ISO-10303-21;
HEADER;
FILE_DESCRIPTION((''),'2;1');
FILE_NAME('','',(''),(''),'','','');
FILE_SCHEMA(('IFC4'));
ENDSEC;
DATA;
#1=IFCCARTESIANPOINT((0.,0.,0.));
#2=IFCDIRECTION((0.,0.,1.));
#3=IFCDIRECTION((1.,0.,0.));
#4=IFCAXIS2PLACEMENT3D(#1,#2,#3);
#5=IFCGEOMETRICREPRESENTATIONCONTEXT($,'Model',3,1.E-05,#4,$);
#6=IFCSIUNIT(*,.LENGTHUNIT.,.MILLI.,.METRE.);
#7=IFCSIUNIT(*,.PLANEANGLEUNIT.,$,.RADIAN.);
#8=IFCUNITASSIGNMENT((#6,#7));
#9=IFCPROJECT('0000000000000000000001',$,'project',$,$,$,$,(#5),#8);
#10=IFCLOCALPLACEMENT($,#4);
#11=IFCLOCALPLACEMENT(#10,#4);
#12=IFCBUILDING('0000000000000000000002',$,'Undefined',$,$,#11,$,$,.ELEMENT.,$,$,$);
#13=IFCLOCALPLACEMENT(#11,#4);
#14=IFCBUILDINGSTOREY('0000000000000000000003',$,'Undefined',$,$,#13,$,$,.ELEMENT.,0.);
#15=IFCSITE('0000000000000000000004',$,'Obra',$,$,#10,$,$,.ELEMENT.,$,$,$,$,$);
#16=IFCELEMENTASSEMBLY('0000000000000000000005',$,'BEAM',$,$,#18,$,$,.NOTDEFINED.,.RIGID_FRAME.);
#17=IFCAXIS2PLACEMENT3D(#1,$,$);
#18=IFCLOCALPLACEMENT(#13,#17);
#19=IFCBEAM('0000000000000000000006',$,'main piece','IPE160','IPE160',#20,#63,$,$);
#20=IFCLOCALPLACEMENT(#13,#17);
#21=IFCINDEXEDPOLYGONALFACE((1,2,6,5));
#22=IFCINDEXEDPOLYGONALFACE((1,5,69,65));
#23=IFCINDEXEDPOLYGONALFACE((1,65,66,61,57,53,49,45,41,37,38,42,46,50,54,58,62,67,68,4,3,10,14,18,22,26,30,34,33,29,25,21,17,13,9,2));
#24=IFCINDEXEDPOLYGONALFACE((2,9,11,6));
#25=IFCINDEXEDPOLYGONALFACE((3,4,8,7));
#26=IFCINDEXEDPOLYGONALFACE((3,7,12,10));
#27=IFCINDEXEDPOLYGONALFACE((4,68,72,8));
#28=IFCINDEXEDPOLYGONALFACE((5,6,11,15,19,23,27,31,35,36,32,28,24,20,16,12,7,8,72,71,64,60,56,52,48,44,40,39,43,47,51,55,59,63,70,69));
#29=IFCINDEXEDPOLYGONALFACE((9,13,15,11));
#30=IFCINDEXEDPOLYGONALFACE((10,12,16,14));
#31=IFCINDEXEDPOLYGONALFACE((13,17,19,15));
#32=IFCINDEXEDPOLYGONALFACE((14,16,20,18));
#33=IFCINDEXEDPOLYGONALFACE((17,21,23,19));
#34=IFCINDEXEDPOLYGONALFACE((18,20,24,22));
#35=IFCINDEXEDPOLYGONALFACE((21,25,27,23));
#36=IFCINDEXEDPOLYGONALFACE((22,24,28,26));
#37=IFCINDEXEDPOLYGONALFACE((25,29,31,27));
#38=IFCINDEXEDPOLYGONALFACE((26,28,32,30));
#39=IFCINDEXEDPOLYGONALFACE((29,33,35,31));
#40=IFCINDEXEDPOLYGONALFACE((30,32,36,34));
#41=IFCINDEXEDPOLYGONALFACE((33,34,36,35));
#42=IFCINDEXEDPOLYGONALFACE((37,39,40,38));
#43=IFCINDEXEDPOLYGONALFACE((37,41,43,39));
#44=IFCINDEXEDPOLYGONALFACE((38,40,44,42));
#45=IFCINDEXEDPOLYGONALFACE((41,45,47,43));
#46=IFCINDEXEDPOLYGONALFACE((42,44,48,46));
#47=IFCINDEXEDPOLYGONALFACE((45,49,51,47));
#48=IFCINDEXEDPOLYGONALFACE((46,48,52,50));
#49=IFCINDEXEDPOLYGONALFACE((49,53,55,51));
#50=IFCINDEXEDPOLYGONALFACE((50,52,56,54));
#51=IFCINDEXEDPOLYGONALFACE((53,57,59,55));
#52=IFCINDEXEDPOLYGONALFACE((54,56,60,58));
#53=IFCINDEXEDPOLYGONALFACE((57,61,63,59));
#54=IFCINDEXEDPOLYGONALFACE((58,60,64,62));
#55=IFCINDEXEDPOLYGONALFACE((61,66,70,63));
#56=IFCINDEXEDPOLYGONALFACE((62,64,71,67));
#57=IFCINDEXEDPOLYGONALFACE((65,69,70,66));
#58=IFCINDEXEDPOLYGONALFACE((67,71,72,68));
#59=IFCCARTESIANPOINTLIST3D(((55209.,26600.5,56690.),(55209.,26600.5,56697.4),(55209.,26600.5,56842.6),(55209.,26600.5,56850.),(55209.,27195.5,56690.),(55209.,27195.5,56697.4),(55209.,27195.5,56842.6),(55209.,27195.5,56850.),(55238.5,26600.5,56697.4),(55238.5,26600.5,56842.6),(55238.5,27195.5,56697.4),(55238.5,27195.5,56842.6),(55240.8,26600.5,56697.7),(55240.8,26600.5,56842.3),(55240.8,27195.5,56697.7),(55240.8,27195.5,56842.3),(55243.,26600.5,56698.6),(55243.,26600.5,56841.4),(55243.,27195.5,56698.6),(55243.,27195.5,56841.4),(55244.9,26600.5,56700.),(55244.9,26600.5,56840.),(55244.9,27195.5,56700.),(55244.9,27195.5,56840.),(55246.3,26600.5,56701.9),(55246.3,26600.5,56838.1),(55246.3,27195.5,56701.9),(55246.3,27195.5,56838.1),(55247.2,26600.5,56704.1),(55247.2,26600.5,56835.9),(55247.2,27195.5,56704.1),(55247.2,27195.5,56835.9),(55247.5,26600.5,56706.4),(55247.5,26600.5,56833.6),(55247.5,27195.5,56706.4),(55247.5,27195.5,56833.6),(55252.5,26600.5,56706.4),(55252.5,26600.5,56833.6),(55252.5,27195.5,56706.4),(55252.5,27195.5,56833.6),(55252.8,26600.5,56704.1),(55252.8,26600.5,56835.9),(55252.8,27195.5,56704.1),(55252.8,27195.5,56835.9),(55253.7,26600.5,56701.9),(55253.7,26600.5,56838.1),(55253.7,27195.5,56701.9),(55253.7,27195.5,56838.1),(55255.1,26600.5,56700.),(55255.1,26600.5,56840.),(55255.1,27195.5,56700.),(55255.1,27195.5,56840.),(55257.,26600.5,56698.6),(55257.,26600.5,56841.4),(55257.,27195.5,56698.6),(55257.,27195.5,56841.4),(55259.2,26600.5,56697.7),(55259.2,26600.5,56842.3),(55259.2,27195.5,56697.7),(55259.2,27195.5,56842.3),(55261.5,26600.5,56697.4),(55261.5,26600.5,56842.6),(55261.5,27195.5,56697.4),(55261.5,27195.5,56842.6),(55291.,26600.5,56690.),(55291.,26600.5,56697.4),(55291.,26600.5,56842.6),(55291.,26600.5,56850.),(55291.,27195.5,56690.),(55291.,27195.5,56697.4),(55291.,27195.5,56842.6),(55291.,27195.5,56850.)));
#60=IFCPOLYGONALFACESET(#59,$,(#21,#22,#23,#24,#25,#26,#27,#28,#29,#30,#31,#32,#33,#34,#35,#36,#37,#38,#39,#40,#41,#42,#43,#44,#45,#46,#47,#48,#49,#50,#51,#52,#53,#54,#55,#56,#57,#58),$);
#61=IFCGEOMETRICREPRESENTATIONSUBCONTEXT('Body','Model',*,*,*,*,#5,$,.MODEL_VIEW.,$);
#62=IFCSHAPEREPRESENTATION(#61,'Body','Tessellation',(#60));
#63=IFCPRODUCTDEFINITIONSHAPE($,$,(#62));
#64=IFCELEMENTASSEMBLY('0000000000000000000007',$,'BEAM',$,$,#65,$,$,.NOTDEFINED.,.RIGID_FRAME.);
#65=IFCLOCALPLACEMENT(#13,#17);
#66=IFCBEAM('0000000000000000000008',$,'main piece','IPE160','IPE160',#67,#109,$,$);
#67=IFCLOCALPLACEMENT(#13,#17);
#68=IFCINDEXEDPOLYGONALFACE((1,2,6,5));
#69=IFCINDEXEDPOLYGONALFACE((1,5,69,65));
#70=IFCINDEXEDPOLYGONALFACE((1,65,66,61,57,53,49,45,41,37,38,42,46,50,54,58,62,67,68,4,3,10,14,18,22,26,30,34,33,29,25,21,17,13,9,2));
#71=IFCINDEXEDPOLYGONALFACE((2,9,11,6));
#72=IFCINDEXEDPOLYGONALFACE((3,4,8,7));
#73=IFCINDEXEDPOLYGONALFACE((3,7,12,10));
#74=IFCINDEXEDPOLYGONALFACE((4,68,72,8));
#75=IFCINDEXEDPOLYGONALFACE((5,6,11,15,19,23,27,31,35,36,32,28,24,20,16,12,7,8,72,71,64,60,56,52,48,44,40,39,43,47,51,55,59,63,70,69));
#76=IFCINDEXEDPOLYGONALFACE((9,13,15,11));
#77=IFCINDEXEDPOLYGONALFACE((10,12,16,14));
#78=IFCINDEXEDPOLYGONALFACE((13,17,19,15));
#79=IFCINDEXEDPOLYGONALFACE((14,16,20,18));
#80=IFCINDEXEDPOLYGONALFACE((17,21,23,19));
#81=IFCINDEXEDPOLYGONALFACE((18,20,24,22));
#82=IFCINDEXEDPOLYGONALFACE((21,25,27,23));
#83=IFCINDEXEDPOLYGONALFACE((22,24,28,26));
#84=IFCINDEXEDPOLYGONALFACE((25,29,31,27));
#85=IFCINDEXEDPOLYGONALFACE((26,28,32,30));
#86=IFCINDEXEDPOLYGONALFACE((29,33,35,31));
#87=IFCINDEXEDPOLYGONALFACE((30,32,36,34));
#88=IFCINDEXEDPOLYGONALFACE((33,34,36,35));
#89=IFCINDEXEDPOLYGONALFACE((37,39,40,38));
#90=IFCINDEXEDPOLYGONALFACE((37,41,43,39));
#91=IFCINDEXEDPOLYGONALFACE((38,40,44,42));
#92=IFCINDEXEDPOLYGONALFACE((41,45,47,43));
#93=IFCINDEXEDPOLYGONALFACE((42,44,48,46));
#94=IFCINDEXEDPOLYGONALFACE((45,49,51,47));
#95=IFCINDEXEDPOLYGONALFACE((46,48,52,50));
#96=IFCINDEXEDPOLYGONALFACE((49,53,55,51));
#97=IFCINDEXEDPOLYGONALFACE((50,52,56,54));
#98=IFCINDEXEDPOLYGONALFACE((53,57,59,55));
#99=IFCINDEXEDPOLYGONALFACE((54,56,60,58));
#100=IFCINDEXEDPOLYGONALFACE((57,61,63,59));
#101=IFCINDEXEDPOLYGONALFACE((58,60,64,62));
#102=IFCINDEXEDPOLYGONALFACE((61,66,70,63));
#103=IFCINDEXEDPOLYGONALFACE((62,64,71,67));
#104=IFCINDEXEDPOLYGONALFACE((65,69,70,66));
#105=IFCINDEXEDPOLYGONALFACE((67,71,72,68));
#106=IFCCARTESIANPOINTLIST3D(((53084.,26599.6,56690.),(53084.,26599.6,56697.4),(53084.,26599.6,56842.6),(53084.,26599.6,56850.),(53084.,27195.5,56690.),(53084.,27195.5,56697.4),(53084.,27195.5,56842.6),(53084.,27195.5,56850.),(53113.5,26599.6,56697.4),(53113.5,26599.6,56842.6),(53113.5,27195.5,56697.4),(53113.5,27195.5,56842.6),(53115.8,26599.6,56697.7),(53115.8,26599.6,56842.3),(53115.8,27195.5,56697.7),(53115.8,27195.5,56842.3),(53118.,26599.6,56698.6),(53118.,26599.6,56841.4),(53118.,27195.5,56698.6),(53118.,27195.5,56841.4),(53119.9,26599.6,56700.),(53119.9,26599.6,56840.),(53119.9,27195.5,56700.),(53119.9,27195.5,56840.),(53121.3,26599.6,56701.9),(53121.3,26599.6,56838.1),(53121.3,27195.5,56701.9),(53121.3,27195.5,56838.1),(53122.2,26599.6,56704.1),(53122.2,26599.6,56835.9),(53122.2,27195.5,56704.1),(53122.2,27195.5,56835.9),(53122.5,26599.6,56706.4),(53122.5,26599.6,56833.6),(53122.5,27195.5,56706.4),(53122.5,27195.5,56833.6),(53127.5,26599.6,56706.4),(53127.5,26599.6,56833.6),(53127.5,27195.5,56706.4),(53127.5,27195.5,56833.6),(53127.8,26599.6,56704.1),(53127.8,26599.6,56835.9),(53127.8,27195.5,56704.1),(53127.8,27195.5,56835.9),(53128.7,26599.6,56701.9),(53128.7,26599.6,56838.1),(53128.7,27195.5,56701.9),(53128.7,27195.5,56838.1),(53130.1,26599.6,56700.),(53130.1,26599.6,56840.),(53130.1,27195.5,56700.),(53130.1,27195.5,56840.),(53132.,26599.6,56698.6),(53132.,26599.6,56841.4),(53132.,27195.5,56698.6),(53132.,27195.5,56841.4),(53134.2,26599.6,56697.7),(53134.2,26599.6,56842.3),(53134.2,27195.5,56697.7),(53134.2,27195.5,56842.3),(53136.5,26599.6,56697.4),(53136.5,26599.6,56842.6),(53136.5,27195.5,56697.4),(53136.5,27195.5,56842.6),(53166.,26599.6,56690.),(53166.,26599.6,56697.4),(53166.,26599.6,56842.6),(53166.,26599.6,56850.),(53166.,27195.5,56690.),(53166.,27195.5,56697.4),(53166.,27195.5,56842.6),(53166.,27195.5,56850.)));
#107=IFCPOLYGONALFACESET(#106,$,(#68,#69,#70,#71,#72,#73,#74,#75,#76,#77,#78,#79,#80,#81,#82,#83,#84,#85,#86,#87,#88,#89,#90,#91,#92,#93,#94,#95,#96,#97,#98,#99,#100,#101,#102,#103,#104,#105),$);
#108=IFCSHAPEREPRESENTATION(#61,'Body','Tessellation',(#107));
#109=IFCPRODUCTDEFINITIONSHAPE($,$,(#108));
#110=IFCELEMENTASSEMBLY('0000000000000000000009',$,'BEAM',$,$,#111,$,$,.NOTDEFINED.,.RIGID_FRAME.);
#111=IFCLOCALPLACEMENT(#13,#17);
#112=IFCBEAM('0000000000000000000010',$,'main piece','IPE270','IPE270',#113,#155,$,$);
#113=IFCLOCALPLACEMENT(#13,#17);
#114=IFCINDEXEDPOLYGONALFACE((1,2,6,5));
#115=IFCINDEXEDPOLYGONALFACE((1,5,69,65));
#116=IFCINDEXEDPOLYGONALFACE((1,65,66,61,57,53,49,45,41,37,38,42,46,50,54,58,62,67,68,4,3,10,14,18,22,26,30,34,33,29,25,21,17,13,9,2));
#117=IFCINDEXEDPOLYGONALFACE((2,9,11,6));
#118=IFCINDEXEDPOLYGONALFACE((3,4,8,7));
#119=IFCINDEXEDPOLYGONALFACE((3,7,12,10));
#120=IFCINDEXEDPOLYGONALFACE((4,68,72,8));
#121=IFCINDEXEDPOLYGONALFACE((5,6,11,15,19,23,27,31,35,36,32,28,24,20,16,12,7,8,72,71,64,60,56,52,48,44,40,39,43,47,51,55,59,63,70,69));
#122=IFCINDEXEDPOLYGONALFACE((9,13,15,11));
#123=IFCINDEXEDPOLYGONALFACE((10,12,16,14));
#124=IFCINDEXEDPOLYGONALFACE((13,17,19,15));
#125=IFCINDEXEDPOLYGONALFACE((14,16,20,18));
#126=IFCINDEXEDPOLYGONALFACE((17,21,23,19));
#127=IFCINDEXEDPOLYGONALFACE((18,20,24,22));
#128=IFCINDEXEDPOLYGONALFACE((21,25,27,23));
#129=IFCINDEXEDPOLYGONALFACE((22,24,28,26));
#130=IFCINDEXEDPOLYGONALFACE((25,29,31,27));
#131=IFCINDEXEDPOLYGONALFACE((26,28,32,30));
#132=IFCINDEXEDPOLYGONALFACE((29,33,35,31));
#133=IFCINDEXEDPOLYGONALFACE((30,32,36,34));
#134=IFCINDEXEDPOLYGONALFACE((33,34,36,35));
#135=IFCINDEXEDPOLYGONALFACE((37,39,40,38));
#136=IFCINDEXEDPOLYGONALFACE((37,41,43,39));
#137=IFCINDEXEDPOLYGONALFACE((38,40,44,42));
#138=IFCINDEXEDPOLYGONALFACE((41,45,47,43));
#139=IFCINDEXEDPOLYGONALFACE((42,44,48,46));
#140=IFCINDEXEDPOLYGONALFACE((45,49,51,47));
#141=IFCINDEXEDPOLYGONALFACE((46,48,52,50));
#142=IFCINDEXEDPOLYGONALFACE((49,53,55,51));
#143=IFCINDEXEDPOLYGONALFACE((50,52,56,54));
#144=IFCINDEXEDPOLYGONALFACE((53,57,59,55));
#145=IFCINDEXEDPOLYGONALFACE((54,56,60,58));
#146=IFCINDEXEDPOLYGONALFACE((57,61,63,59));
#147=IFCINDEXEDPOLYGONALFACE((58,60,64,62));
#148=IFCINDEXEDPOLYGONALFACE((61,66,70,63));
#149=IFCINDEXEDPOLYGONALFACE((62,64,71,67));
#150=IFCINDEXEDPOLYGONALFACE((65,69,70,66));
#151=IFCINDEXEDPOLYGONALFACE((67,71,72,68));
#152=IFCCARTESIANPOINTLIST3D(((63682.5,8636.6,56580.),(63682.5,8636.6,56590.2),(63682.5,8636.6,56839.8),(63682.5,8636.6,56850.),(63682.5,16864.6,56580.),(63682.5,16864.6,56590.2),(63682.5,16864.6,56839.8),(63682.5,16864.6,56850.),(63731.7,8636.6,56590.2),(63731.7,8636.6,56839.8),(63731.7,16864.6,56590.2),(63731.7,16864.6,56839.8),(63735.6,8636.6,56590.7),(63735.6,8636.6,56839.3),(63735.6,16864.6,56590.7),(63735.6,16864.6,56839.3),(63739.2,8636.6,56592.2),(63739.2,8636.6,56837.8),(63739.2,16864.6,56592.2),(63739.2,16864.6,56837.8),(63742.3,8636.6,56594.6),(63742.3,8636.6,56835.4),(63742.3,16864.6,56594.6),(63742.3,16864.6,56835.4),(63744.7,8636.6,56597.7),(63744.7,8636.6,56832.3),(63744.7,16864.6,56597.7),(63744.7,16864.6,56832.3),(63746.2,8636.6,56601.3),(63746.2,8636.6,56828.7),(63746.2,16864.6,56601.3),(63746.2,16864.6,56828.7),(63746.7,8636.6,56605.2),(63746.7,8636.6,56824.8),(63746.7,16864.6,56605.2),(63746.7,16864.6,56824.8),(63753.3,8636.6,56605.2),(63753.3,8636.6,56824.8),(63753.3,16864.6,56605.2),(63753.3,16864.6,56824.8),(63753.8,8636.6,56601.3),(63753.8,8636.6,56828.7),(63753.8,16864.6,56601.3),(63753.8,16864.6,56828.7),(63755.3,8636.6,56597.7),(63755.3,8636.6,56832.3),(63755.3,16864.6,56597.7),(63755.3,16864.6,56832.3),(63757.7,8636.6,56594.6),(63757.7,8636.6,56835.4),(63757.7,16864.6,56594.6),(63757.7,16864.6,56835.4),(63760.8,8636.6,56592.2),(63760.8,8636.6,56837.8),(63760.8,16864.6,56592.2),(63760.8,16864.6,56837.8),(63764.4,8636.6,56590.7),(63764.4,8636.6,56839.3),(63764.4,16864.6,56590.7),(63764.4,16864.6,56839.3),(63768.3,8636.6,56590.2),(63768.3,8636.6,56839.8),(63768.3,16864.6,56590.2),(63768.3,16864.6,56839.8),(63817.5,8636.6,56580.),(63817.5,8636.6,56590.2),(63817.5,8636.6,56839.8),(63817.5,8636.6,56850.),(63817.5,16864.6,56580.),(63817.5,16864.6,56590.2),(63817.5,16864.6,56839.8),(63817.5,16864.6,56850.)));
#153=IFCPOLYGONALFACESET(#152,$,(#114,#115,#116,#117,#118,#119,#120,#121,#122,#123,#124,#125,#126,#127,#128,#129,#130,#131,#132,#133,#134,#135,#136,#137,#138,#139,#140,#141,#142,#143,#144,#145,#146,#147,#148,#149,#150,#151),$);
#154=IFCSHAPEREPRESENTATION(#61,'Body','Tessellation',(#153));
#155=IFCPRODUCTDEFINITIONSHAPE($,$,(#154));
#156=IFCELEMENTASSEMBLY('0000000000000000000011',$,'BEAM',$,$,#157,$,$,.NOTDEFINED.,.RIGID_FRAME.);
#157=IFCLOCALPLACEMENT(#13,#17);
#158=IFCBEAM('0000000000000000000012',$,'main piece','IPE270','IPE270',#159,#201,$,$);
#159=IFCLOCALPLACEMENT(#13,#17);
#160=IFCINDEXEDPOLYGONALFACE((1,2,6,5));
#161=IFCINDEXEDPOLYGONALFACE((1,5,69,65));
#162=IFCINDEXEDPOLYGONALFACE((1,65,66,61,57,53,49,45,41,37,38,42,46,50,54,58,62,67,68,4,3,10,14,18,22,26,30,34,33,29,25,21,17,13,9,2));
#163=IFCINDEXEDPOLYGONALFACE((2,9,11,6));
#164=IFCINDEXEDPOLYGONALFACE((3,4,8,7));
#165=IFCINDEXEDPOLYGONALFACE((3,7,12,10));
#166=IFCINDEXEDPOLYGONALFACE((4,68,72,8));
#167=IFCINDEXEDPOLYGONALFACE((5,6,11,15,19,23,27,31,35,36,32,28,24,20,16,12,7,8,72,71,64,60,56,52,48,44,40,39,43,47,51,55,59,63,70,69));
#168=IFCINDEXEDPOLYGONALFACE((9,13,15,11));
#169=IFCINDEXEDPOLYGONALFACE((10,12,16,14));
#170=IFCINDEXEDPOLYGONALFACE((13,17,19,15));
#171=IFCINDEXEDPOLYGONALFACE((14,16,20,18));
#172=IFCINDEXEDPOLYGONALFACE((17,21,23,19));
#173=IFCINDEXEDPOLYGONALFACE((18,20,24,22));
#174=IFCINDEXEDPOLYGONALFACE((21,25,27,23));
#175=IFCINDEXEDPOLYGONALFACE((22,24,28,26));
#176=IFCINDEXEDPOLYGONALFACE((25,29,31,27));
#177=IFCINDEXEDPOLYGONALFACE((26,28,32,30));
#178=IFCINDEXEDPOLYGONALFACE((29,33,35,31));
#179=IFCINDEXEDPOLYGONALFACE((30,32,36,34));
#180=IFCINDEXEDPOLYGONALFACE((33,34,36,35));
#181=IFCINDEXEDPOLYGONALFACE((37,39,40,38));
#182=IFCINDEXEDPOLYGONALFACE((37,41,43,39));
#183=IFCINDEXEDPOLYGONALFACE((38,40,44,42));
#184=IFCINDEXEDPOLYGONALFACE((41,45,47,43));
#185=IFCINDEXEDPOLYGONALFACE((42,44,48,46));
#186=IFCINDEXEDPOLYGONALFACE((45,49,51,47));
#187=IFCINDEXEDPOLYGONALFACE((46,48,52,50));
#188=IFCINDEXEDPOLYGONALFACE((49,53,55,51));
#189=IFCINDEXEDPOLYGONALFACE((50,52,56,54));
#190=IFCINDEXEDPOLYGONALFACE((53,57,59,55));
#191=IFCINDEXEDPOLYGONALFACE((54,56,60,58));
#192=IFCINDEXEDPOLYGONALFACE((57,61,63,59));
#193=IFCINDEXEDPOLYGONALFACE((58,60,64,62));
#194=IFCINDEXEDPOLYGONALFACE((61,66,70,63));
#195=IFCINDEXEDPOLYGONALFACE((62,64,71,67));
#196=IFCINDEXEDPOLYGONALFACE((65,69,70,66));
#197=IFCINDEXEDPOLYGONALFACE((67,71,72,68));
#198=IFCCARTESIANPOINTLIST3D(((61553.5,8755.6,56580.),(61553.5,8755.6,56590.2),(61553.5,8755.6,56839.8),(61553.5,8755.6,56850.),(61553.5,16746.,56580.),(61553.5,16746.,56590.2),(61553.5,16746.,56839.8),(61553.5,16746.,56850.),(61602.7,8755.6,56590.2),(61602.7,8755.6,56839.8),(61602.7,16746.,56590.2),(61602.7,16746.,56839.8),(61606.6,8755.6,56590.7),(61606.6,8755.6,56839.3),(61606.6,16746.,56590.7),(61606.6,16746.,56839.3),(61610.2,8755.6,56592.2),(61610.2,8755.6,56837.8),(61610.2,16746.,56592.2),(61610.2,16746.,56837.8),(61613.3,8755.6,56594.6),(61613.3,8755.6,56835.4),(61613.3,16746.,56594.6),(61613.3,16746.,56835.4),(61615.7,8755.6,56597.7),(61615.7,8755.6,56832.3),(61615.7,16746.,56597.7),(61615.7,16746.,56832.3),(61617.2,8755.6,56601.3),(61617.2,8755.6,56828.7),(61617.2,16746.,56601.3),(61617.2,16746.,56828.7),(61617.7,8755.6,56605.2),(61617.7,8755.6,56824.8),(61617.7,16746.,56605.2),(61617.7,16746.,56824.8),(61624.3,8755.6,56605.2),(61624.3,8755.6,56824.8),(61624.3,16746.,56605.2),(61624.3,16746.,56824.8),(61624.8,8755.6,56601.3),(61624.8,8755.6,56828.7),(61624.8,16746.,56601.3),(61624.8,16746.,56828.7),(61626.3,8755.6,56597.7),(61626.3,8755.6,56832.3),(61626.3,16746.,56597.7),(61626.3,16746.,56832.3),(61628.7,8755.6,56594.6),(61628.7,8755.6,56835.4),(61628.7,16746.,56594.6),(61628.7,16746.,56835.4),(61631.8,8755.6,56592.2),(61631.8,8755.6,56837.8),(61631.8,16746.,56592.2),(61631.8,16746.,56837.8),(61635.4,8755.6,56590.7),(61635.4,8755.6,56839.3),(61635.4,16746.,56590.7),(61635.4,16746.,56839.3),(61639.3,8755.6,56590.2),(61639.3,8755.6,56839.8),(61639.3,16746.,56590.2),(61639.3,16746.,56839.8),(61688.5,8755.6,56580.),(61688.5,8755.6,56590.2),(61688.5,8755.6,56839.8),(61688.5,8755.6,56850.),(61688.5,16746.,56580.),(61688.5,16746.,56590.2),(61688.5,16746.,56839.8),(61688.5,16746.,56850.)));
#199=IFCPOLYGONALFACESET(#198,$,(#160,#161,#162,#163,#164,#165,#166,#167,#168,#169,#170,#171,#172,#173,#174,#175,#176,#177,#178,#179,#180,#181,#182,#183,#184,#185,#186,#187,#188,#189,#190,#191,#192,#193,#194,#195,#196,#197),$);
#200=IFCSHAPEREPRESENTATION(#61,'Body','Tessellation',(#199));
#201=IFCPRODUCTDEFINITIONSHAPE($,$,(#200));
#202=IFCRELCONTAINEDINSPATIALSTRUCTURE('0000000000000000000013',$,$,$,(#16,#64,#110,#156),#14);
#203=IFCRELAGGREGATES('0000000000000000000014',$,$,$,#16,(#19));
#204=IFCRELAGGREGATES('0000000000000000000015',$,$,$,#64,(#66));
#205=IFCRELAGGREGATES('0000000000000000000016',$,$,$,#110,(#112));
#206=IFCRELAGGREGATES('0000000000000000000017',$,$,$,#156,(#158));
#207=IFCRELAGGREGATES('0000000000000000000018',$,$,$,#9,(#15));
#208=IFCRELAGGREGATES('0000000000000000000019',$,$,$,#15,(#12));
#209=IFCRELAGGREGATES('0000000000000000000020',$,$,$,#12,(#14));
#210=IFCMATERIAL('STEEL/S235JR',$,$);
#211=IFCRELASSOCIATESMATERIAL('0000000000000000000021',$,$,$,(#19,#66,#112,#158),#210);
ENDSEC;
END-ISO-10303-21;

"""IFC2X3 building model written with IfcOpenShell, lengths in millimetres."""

from ifc_helpers import new_model, si_unit, frame, origin_with_axes, origin_2d_with_axis, place, context, subcontext, project, spatial, i_section, extrude, material, element, aggregate, save


model = new_model("IFC2X3")

# Units and contexts
model_context = context("Model", 3, precision=1e-05, world=origin_with_axes())
body_context = subcontext(model_context, "Body", "Model", "MODEL_VIEW")
ifc_project = project(units=[si_unit("LENGTHUNIT", "METRE", prefix="MILLI"), si_unit("PLANEANGLEUNIT", "RADIAN")], contexts=[model_context])

# Site, building, storey
site_placement = place(None, origin_with_axes())
site = spatial("IfcSite", under=ifc_project, at=site_placement, Name="Obra", CompositionType="ELEMENT")
building_placement = place(site_placement, origin_with_axes())
building = spatial("IfcBuilding", under=site, at=building_placement, Name="Undefined", CompositionType="ELEMENT")
storey_placement = place(building_placement, origin_with_axes())
storey = spatial("IfcBuildingStorey", under=building, at=storey_placement, Name="Undefined", CompositionType="ELEMENT", Elevation=0.0)

# Element assemblies, beams
ifc_material_1 = material(Name="STEEL/S235JR")
assembly_1_placement = place(storey_placement, origin_with_axes())
assembly_1 = element("IfcElementAssembly", 1, at=assembly_1_placement, inside=storey, Name="BEAM", AssemblyPlace="NOTDEFINED", PredefinedType="RIGID_FRAME")
beam_1_placement = place(assembly_1_placement, frame((55250.0, 26600.5, 56770.0), z_axis=(0.0, 0.0, 1.0), x_axis=(0.0, 1.0, 0.0)))
beam_1 = element("IfcBeam", 2, at=beam_1_placement, material=ifc_material_1, Name="main piece", Description="IPE160", ObjectType="IPE160", context=body_context, shape_type="SweptSolid", body=[
    extrude(i_section(OverallWidth=82.0, OverallDepth=160.0, WebThickness=5.0, FlangeThickness=7.4, FilletRadius=9.0, at=origin_2d_with_axis()), frame((595.0, 0.0, 0.0), z_axis=(-1.0, 0.0, 0.0), x_axis=(0.0, -1.0, 0.0)), (0.0, 0.0, 1.0), 595.0),
])
aggregate(assembly_1, [beam_1])
assembly_2_placement = place(storey_placement, origin_with_axes())
assembly_2 = element("IfcElementAssembly", 3, at=assembly_2_placement, inside=storey, Name="BEAM", AssemblyPlace="NOTDEFINED", PredefinedType="RIGID_FRAME")
beam_2_placement = place(assembly_2_placement, frame((53125.0, 26599.6, 56770.0), z_axis=(0.0, 0.0, 1.0), x_axis=(0.0, 1.0, 0.0)))
beam_2 = element("IfcBeam", 4, at=beam_2_placement, material=ifc_material_1, Name="main piece", Description="IPE160", ObjectType="IPE160", context=body_context, shape_type="SweptSolid", body=[
    extrude(i_section(OverallWidth=82.0, OverallDepth=160.0, WebThickness=5.0, FlangeThickness=7.4, FilletRadius=9.0, at=origin_2d_with_axis()), frame((595.9, 0.0, 0.0), z_axis=(-1.0, 0.0, 0.0), x_axis=(0.0, -1.0, 0.0)), (0.0, 0.0, 1.0), 595.9),
])
aggregate(assembly_2, [beam_2])
assembly_3_placement = place(storey_placement, origin_with_axes())
assembly_3 = element("IfcElementAssembly", 5, at=assembly_3_placement, inside=storey, Name="BEAM", AssemblyPlace="NOTDEFINED", PredefinedType="RIGID_FRAME")
beam_3_placement = place(assembly_3_placement, frame((63750.0, 8636.6, 56715.0), z_axis=(0.0, 0.0, 1.0), x_axis=(0.0, 1.0, 0.0)))
beam_3 = element("IfcBeam", 6, at=beam_3_placement, material=ifc_material_1, Name="main piece", Description="IPE270", ObjectType="IPE270", context=body_context, shape_type="SweptSolid", body=[
    extrude(i_section(OverallWidth=135.0, OverallDepth=270.0, WebThickness=6.6, FlangeThickness=10.2, FilletRadius=15.0, at=origin_2d_with_axis()), frame((8228.0, 0.0, 0.0), z_axis=(-1.0, 0.0, 0.0), x_axis=(0.0, -1.0, 0.0)), (0.0, 0.0, 1.0), 8228.0),
])
aggregate(assembly_3, [beam_3])

# Element assembly, beam
assembly_4_placement = place(storey_placement, origin_with_axes())
assembly_4 = element("IfcElementAssembly", 7, at=assembly_4_placement, inside=storey, Name="BEAM", AssemblyPlace="NOTDEFINED", PredefinedType="RIGID_FRAME")
beam_4_placement = place(assembly_4_placement, frame((61621.0, 8755.6, 56715.0), z_axis=(0.0, 0.0, 1.0), x_axis=(0.0, 1.0, 0.0)))
beam_4 = element("IfcBeam", 8, at=beam_4_placement, material=ifc_material_1, Name="main piece", Description="IPE270", ObjectType="IPE270", context=body_context, shape_type="SweptSolid", body=[
    extrude(i_section(OverallWidth=135.0, OverallDepth=270.0, WebThickness=6.6, FlangeThickness=10.2, FilletRadius=15.0, at=origin_2d_with_axis()), frame((7990.4, 0.0, 0.0), z_axis=(-1.0, 0.0, 0.0), x_axis=(0.0, -1.0, 0.0)), (0.0, 0.0, 1.0), 7990.4),
])
aggregate(assembly_4, [beam_4])

save(model, "model.ifc")
